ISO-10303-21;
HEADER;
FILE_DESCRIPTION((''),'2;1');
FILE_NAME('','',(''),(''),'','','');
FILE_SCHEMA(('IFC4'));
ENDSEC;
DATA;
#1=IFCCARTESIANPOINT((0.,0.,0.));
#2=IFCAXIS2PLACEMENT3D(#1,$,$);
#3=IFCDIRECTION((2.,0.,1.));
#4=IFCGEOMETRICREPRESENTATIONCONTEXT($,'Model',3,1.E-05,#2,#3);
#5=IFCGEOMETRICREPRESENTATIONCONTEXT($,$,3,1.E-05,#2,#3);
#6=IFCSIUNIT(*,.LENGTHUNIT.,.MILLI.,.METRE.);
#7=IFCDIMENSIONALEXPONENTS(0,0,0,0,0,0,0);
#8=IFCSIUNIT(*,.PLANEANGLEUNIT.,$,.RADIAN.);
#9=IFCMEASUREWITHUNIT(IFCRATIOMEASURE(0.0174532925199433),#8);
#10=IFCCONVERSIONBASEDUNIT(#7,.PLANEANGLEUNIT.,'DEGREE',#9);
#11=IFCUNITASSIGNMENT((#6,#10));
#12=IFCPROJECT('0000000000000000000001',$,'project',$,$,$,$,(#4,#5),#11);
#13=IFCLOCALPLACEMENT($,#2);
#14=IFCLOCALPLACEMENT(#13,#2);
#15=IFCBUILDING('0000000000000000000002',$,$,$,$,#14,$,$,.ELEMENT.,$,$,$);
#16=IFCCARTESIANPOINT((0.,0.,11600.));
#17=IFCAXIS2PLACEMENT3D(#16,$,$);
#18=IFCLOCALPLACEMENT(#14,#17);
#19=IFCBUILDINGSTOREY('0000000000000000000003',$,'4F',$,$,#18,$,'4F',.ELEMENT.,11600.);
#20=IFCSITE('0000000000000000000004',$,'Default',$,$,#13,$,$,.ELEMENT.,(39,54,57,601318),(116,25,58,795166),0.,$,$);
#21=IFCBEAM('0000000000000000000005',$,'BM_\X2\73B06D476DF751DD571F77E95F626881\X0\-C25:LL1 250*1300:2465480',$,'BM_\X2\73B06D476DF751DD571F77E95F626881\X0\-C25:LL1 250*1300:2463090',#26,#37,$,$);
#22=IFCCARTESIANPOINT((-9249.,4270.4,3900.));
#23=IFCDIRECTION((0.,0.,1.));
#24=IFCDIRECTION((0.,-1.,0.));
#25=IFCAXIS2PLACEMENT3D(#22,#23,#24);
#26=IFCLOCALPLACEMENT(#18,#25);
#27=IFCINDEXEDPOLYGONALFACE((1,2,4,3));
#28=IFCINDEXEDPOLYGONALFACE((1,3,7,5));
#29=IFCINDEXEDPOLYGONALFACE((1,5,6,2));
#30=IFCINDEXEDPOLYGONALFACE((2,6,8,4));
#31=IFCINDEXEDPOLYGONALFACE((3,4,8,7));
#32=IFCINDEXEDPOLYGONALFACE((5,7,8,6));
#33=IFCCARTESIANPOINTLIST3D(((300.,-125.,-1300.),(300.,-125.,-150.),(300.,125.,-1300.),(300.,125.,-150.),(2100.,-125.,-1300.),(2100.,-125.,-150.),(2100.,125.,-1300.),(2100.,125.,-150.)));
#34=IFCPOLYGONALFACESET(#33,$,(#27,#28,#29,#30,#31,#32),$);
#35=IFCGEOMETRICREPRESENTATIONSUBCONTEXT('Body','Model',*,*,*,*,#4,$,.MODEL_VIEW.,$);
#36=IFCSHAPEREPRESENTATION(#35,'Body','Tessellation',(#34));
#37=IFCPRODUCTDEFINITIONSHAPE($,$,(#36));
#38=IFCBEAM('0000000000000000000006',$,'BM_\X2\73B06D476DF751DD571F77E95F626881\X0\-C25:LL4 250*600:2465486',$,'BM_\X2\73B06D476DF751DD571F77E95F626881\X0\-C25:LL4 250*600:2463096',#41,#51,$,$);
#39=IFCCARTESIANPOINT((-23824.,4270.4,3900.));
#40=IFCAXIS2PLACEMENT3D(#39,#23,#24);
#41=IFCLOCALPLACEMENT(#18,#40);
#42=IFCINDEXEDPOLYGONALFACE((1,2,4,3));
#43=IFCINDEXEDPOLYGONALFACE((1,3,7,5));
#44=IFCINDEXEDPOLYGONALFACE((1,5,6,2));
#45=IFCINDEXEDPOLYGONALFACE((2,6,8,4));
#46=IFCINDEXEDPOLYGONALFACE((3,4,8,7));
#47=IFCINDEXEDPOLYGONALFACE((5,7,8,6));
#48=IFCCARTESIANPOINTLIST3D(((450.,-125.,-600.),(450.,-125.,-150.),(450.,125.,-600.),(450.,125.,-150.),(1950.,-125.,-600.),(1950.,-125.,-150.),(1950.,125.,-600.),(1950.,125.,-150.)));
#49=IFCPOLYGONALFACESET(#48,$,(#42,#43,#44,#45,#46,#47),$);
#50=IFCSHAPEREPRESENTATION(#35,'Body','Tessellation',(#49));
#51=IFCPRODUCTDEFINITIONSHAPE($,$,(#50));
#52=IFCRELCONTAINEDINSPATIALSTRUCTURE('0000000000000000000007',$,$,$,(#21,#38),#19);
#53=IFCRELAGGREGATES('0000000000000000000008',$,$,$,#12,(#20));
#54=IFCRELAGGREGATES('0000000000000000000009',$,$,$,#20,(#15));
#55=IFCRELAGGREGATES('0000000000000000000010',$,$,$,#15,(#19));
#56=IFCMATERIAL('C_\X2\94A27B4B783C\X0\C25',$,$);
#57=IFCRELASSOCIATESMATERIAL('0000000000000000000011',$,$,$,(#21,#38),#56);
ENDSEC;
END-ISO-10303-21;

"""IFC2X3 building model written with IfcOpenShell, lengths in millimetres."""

from ifc_helpers import new_model, entity, si_unit, converted_unit, direction, frame, frame_2d, origin, place, context, subcontext, project, spatial, rectangle, extrude, material, element, save


model = new_model("IFC2X3")

# Units and contexts
model_context = context("Model", 3, precision=1e-05, world=origin(), true_north=direction((2.0, 0.0, 1.0)))
context_of_model = context(None, 3, precision=1e-05, world=origin(), true_north=direction((2.0, 0.0, 1.0)))
body_context = subcontext(model_context, "Body", "Model", "MODEL_VIEW")
ifc_project = project(units=[si_unit("LENGTHUNIT", "METRE", prefix="MILLI"), converted_unit("PLANEANGLEUNIT", "DEGREE", entity("IfcRatioMeasure", 0.0174532925199433), si_unit("PLANEANGLEUNIT", "RADIAN"), dimensions=[0, 0, 0, 0, 0, 0, 0])], contexts=[model_context, context_of_model])

# Site, building, storey
site_placement = place(None, origin())
site = spatial("IfcSite", under=ifc_project, at=site_placement, Name="Default", CompositionType="ELEMENT", RefLatitude=(39, 54, 57, 601318), RefLongitude=(116, 25, 58, 795166), RefElevation=0.0)
building_placement = place(site_placement, origin())
building = spatial("IfcBuilding", under=site, at=building_placement, CompositionType="ELEMENT")
storey_placement = place(building_placement, frame((0.0, 0.0, 11600.0)))
storey = spatial("IfcBuildingStorey", under=building, at=storey_placement, Name="4F", LongName="4F", CompositionType="ELEMENT", Elevation=11600.0)

# Beams
ifc_material = material(Name="C_钢筋砼C25")
beam_1_placement = place(storey_placement, frame((-9249.0, 4270.4, 3900.0), z_axis=(0.0, 0.0, 1.0), x_axis=(0.0, -1.0, 0.0)))
element("IfcBeam", 1, at=beam_1_placement, inside=storey, material=ifc_material, Name="BM_现浇混凝土矩形梁-C25:LL1 250*1300:2465480", ObjectType="BM_现浇混凝土矩形梁-C25:LL1 250*1300:2463090", context=body_context, shape_type="SweptSolid", body=[
    extrude(rectangle(XDim=1150.0, YDim=250.0, at=frame_2d((0.0, 0.0), x_axis=(1.0, 0.0))), frame((300.0, 0.0, -725.0), z_axis=(1.0, 0.0, 0.0), x_axis=(0.0, 0.0, -1.0)), (0.0, 0.0, 1.0), 1800.0),
])
beam_2_placement = place(storey_placement, frame((-23824.0, 4270.4, 3900.0), z_axis=(0.0, 0.0, 1.0), x_axis=(0.0, -1.0, 0.0)))
element("IfcBeam", 2, at=beam_2_placement, inside=storey, material=ifc_material, Name="BM_现浇混凝土矩形梁-C25:LL4 250*600:2465486", ObjectType="BM_现浇混凝土矩形梁-C25:LL4 250*600:2463096", context=body_context, shape_type="SweptSolid", body=[
    extrude(rectangle(XDim=450.0, YDim=250.0, at=frame_2d((0.0, 0.0), x_axis=(1.0, 0.0))), frame((450.0, 0.0, -375.0), z_axis=(1.0, 0.0, 0.0), x_axis=(0.0, 0.0, -1.0)), (0.0, 0.0, 1.0), 1500.0),
])

save(model, "model.ifc")
